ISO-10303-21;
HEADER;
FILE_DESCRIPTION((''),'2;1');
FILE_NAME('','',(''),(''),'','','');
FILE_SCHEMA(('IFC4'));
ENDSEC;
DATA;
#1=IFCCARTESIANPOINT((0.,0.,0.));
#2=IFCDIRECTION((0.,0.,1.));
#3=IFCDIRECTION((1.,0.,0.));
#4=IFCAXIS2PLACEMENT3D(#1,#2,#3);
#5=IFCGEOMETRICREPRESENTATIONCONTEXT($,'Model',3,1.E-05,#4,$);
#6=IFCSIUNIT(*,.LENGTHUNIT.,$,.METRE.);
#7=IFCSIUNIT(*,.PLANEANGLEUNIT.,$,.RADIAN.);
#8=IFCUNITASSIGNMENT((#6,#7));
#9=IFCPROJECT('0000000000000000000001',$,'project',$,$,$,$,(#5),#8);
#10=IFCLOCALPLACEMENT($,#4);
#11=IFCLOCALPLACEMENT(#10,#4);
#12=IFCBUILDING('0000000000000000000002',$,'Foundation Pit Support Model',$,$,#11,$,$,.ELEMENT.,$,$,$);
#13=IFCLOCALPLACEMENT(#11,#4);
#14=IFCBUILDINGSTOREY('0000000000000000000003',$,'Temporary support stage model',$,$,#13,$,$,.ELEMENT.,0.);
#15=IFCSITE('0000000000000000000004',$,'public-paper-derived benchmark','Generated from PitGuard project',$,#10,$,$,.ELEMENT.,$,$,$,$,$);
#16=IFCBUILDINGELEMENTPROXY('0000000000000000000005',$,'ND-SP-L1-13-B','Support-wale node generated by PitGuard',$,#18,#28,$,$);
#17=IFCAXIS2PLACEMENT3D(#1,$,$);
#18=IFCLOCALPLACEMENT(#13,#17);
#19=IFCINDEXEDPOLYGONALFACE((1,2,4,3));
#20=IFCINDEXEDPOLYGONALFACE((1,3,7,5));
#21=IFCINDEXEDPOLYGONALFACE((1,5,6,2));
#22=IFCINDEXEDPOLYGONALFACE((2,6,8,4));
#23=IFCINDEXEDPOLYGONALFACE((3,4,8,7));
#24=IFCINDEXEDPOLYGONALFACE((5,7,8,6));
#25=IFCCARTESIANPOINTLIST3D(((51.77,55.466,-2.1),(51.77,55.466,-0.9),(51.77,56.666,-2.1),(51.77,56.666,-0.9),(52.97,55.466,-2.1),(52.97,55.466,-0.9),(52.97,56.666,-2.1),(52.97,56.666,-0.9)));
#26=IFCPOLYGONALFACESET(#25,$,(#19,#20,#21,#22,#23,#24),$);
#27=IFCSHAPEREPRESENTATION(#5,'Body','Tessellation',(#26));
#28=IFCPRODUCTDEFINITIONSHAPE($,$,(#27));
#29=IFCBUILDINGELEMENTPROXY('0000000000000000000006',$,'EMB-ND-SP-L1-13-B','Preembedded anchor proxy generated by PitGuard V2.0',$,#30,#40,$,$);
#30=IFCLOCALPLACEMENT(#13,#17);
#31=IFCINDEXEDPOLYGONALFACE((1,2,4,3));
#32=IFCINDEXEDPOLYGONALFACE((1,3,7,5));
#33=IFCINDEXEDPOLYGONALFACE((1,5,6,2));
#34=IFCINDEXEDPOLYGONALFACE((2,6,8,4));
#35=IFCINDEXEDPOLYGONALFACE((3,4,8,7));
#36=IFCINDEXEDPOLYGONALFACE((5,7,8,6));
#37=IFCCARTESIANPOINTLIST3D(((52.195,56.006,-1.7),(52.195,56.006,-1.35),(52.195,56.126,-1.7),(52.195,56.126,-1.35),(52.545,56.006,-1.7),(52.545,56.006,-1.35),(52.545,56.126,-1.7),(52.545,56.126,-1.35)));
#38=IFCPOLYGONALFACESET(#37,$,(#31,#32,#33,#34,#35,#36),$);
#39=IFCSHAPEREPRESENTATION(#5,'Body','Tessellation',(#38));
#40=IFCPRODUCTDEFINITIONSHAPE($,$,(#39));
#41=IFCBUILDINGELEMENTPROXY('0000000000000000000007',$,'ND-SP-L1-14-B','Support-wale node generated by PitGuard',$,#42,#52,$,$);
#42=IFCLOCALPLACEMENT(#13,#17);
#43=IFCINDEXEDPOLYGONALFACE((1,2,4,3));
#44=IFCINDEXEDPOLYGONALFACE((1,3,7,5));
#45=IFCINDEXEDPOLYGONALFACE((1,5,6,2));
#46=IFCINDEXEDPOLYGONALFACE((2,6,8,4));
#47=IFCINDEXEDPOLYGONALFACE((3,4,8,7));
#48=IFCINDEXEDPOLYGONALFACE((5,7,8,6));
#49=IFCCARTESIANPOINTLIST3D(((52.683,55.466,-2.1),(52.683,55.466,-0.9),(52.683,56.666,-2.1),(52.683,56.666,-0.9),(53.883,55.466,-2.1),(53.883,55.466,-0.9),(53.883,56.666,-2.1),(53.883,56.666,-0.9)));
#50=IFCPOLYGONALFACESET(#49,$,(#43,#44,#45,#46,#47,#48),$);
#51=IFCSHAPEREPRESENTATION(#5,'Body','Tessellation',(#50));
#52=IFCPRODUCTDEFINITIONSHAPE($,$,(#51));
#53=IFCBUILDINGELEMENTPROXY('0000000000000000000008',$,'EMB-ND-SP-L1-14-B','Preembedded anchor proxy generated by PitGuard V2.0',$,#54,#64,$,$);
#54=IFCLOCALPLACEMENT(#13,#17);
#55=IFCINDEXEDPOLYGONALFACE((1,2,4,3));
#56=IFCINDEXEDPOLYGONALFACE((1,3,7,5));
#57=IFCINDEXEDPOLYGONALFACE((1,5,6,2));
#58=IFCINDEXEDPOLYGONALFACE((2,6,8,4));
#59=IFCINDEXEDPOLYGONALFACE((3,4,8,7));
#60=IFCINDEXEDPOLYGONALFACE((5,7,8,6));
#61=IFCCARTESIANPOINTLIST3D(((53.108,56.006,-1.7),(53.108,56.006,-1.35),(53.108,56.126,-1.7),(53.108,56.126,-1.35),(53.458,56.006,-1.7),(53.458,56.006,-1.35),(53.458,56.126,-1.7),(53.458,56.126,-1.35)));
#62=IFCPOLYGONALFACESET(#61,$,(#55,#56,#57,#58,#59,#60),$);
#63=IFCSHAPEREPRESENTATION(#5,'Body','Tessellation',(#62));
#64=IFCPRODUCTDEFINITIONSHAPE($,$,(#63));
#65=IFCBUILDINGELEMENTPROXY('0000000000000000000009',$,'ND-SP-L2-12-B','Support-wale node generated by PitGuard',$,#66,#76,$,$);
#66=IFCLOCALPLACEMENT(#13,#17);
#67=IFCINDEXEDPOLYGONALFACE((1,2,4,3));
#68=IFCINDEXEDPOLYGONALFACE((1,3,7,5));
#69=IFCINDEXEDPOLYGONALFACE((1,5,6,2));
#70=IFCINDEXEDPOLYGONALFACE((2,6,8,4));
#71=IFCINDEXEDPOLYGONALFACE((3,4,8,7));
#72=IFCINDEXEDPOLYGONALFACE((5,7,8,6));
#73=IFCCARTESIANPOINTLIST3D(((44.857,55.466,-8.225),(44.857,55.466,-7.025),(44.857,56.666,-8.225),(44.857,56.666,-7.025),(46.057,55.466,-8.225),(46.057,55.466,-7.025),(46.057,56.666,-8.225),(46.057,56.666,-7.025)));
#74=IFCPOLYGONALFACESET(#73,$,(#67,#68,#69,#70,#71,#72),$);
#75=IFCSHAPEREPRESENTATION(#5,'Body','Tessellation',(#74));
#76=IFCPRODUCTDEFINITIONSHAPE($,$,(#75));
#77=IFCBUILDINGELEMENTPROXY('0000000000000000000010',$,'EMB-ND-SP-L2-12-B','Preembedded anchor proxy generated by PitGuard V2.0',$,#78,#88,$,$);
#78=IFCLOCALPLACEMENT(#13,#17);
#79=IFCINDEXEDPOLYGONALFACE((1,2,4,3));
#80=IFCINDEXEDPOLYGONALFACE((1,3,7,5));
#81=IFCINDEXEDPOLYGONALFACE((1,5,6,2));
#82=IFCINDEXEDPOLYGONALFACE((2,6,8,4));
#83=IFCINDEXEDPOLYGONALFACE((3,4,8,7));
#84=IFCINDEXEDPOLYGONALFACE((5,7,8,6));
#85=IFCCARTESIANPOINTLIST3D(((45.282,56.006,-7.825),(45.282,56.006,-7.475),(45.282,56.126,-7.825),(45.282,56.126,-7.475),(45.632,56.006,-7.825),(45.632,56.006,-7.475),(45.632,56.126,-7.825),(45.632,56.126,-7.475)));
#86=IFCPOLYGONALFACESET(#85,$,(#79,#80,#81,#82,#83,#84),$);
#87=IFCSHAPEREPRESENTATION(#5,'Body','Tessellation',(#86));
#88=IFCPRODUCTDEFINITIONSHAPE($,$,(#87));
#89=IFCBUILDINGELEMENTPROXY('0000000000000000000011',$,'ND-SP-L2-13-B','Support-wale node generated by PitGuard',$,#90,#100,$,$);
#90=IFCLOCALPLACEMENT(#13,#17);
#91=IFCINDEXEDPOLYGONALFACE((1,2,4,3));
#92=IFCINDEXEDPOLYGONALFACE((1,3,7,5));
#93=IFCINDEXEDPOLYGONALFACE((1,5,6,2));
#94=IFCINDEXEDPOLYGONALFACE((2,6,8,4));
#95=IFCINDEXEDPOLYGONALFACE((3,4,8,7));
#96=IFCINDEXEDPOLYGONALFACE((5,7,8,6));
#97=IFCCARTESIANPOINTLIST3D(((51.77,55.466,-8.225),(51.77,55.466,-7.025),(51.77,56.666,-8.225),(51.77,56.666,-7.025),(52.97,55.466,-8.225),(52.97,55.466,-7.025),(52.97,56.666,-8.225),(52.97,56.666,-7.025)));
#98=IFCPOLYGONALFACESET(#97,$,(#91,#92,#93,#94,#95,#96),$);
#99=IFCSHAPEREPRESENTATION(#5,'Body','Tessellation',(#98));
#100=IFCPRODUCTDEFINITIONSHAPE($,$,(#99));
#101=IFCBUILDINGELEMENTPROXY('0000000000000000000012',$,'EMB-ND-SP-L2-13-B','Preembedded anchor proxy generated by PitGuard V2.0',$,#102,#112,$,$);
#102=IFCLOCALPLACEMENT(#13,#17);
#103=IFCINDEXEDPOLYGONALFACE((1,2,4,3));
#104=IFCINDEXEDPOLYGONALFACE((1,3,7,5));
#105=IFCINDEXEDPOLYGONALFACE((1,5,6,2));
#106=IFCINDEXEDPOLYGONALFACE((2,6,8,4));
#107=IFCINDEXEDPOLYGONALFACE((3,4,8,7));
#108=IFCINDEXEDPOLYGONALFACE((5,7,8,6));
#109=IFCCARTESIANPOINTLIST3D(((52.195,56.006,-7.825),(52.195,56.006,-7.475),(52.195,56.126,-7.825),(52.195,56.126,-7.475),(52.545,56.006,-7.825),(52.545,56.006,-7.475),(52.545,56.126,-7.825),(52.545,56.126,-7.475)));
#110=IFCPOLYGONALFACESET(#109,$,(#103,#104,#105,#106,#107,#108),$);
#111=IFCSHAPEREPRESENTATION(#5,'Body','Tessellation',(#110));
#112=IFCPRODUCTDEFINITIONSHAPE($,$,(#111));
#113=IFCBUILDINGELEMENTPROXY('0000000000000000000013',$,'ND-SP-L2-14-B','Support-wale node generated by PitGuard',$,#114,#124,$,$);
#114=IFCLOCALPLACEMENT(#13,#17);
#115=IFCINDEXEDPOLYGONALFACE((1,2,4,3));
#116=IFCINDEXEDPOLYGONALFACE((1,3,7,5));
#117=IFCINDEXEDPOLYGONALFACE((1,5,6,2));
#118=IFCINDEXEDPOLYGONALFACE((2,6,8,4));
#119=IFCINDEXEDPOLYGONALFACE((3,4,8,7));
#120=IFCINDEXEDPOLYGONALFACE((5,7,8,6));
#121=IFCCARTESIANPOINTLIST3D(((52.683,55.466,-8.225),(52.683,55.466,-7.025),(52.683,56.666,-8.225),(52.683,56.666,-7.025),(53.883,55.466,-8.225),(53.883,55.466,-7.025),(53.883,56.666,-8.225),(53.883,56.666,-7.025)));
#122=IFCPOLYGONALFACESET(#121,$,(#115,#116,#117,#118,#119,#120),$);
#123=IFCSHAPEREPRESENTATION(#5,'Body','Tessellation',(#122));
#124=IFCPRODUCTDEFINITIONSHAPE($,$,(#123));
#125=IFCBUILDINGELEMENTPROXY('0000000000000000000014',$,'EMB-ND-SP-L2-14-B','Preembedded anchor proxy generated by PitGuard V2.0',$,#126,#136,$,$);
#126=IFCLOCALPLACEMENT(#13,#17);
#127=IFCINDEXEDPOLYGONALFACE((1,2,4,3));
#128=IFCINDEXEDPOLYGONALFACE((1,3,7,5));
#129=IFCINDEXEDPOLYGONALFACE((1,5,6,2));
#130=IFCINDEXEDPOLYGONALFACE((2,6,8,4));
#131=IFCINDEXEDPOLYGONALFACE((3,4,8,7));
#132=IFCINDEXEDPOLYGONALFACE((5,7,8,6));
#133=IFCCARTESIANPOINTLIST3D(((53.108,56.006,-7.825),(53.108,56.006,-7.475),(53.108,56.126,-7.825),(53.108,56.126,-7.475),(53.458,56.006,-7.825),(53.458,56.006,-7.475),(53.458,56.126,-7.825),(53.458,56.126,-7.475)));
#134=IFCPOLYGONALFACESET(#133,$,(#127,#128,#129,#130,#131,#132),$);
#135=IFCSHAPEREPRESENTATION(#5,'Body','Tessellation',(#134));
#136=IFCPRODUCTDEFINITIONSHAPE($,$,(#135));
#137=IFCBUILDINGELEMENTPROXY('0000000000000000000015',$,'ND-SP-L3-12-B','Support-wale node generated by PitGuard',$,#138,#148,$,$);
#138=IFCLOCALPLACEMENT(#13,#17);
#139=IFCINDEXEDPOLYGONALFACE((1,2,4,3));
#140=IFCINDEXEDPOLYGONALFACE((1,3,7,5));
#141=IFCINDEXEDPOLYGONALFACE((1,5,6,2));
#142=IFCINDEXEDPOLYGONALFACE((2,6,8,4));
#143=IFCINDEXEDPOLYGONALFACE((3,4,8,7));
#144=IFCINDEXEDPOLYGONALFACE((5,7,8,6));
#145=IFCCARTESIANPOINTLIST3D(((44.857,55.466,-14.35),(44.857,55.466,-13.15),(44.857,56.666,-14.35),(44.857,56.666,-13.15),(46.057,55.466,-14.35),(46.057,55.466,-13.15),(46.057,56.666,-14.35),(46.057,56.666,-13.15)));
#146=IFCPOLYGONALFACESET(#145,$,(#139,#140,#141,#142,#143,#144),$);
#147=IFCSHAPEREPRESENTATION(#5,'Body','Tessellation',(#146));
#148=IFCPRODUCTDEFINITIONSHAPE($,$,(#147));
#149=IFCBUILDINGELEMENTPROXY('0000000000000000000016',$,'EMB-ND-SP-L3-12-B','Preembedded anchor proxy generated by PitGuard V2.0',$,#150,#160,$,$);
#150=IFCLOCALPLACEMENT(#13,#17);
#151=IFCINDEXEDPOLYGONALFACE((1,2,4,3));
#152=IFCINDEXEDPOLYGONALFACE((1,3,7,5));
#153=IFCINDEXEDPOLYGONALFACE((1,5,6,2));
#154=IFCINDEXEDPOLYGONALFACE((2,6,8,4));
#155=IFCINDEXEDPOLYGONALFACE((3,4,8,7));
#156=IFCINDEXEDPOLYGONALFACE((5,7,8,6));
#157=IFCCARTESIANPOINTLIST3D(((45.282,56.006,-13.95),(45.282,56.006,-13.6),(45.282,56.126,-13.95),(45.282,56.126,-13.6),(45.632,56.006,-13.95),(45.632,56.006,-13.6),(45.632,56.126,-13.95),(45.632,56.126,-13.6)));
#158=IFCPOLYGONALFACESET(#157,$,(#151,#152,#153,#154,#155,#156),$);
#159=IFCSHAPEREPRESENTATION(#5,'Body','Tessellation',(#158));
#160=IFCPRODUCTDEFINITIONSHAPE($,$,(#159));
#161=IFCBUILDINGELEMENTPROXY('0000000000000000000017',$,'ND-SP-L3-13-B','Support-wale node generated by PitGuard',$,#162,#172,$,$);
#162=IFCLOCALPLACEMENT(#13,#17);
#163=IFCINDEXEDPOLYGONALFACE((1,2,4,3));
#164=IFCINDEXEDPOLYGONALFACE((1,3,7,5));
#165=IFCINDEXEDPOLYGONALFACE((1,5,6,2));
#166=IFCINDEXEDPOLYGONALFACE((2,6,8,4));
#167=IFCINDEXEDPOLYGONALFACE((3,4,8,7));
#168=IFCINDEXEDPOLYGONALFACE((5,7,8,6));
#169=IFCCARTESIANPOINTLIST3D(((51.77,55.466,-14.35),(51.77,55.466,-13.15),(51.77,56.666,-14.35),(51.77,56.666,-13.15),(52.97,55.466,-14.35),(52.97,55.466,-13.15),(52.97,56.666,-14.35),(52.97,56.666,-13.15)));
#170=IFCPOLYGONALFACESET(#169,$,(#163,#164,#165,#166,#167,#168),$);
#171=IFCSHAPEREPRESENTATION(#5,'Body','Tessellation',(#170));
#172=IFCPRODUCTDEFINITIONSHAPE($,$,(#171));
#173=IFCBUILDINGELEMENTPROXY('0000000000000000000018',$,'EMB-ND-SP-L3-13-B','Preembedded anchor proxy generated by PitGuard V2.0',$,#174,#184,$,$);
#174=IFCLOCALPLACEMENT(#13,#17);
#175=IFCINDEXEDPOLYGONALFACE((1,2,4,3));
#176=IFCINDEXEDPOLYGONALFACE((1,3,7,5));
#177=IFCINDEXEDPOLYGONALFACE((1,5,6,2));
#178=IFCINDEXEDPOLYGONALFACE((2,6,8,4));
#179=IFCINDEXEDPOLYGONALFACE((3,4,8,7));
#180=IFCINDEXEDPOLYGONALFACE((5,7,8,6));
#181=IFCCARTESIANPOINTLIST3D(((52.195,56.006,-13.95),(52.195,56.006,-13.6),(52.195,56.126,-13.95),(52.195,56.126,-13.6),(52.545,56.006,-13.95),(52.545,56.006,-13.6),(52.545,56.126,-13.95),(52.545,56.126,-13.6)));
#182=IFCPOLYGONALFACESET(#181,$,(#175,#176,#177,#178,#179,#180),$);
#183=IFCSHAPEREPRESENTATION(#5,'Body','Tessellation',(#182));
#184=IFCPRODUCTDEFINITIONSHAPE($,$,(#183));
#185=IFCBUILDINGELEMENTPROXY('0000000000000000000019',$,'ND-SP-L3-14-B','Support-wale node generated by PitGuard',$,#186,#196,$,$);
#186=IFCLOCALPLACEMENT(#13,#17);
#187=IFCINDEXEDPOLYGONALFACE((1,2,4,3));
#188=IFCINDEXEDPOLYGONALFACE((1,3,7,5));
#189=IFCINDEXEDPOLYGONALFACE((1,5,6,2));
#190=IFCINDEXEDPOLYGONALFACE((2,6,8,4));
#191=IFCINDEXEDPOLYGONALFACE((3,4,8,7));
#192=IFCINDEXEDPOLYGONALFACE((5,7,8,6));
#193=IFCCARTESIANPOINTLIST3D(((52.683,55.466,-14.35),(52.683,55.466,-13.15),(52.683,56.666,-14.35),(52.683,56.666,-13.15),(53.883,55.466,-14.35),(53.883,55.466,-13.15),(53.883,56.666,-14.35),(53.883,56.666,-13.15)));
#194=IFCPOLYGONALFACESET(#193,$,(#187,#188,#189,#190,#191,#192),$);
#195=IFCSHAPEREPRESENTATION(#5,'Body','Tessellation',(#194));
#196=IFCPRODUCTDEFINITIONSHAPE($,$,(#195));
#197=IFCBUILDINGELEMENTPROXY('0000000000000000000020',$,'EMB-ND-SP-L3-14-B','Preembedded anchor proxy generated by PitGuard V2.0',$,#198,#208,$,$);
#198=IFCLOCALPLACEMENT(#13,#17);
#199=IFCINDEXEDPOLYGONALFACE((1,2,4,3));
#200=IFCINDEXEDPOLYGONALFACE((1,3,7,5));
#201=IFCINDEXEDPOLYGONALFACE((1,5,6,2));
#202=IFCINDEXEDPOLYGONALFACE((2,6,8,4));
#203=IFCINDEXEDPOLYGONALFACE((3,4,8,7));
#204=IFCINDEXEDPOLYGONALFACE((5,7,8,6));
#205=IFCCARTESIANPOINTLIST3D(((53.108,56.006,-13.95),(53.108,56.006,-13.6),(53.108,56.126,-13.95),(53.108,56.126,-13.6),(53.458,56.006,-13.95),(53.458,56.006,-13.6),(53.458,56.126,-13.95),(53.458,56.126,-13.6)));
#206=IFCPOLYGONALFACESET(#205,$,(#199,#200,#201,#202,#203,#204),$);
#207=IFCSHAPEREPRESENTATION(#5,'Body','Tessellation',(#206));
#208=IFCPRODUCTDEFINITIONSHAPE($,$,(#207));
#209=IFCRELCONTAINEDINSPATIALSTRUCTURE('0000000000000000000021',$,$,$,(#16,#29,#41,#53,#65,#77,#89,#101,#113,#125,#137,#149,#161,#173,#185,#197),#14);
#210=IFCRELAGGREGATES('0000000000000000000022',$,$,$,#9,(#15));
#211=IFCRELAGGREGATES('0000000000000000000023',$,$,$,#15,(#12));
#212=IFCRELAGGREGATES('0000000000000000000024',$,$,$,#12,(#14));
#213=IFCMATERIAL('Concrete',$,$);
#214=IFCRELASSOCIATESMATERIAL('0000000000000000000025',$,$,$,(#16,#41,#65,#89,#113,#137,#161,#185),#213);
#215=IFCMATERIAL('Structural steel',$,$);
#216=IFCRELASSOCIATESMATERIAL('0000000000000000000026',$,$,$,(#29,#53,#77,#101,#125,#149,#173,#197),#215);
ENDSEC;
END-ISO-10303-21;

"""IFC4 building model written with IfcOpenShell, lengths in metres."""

from ifc_helpers import new_model, si_unit, frame, origin_with_axes, origin_2d, place, context, project, spatial, rectangle, extrude, material, element, save


model = new_model("IFC4")

# Units and contexts
model_context = context("Model", 3, precision=1e-05, world=origin_with_axes())
ifc_project = project(units=[si_unit("LENGTHUNIT", "METRE"), si_unit("PLANEANGLEUNIT", "RADIAN")], contexts=[model_context])

# Site, building, storey
site_placement = place(None, origin_with_axes())
site = spatial("IfcSite", under=ifc_project, at=site_placement, Name="public-paper-derived benchmark", Description="Generated from PitGuard project", CompositionType="ELEMENT")
building_placement = place(site_placement, origin_with_axes())
building = spatial("IfcBuilding", under=site, at=building_placement, Name="Foundation Pit Support Model", CompositionType="ELEMENT")
storey_placement = place(building_placement, origin_with_axes())
storey = spatial("IfcBuildingStorey", under=building, at=storey_placement, Name="Temporary support stage model", CompositionType="ELEMENT", Elevation=0.0)

# Shared definitions
ifc_material_1 = material(Name="Concrete")

# Shared definitions
ifc_material_2 = material(Name="Structural steel")

# Building element proxies
proxy_1_placement = place(storey_placement, frame((52.37, 56.066, -2.1), z_axis=(0.0, 0.0, 1.0), x_axis=(1.0, 0.0, 0.0)))
element("IfcBuildingElementProxy", 1, at=proxy_1_placement, inside=storey, material=ifc_material_1, Name="ND-SP-L1-13-B", Description="Support-wale node generated by PitGuard", context=model_context, shape_type="SweptSolid", body=[
    extrude(rectangle(XDim=1.2, YDim=1.2, at=origin_2d()), origin_with_axes(), (0.0, 0.0, 1.0), 1.2),
])
proxy_2_placement = place(storey_placement, frame((52.37, 56.066, -1.7), z_axis=(0.0, 0.0, 1.0), x_axis=(1.0, 0.0, 0.0)))
element("IfcBuildingElementProxy", 2, at=proxy_2_placement, inside=storey, material=ifc_material_2, Name="EMB-ND-SP-L1-13-B", Description="Preembedded anchor proxy generated by PitGuard V2.0", context=model_context, shape_type="SweptSolid", body=[
    extrude(rectangle(XDim=0.35, YDim=0.12, at=origin_2d()), origin_with_axes(), (0.0, 0.0, 1.0), 0.35),
])
proxy_3_placement = place(storey_placement, frame((53.283, 56.066, -2.1), z_axis=(0.0, 0.0, 1.0), x_axis=(1.0, 0.0, 0.0)))
element("IfcBuildingElementProxy", 3, at=proxy_3_placement, inside=storey, material=ifc_material_1, Name="ND-SP-L1-14-B", Description="Support-wale node generated by PitGuard", context=model_context, shape_type="SweptSolid", body=[
    extrude(rectangle(XDim=1.2, YDim=1.2, at=origin_2d()), origin_with_axes(), (0.0, 0.0, 1.0), 1.2),
])
proxy_4_placement = place(storey_placement, frame((53.283, 56.066, -1.7), z_axis=(0.0, 0.0, 1.0), x_axis=(1.0, 0.0, 0.0)))
element("IfcBuildingElementProxy", 4, at=proxy_4_placement, inside=storey, material=ifc_material_2, Name="EMB-ND-SP-L1-14-B", Description="Preembedded anchor proxy generated by PitGuard V2.0", context=model_context, shape_type="SweptSolid", body=[
    extrude(rectangle(XDim=0.35, YDim=0.12, at=origin_2d()), origin_with_axes(), (0.0, 0.0, 1.0), 0.35),
])
proxy_5_placement = place(storey_placement, frame((45.457, 56.066, -8.225), z_axis=(0.0, 0.0, 1.0), x_axis=(1.0, 0.0, 0.0)))
element("IfcBuildingElementProxy", 5, at=proxy_5_placement, inside=storey, material=ifc_material_1, Name="ND-SP-L2-12-B", Description="Support-wale node generated by PitGuard", context=model_context, shape_type="SweptSolid", body=[
    extrude(rectangle(XDim=1.2, YDim=1.2, at=origin_2d()), origin_with_axes(), (0.0, 0.0, 1.0), 1.2),
])
proxy_6_placement = place(storey_placement, frame((45.457, 56.066, -7.825), z_axis=(0.0, 0.0, 1.0), x_axis=(1.0, 0.0, 0.0)))
element("IfcBuildingElementProxy", 6, at=proxy_6_placement, inside=storey, material=ifc_material_2, Name="EMB-ND-SP-L2-12-B", Description="Preembedded anchor proxy generated by PitGuard V2.0", context=model_context, shape_type="SweptSolid", body=[
    extrude(rectangle(XDim=0.35, YDim=0.12, at=origin_2d()), origin_with_axes(), (0.0, 0.0, 1.0), 0.35),
])
proxy_7_placement = place(storey_placement, frame((52.37, 56.066, -8.225), z_axis=(0.0, 0.0, 1.0), x_axis=(1.0, 0.0, 0.0)))
element("IfcBuildingElementProxy", 7, at=proxy_7_placement, inside=storey, material=ifc_material_1, Name="ND-SP-L2-13-B", Description="Support-wale node generated by PitGuard", context=model_context, shape_type="SweptSolid", body=[
    extrude(rectangle(XDim=1.2, YDim=1.2, at=origin_2d()), origin_with_axes(), (0.0, 0.0, 1.0), 1.2),
])
proxy_8_placement = place(storey_placement, frame((52.37, 56.066, -7.825), z_axis=(0.0, 0.0, 1.0), x_axis=(1.0, 0.0, 0.0)))
element("IfcBuildingElementProxy", 8, at=proxy_8_placement, inside=storey, material=ifc_material_2, Name="EMB-ND-SP-L2-13-B", Description="Preembedded anchor proxy generated by PitGuard V2.0", context=model_context, shape_type="SweptSolid", body=[
    extrude(rectangle(XDim=0.35, YDim=0.12, at=origin_2d()), origin_with_axes(), (0.0, 0.0, 1.0), 0.35),
])
proxy_9_placement = place(storey_placement, frame((53.283, 56.066, -8.225), z_axis=(0.0, 0.0, 1.0), x_axis=(1.0, 0.0, 0.0)))
element("IfcBuildingElementProxy", 9, at=proxy_9_placement, inside=storey, material=ifc_material_1, Name="ND-SP-L2-14-B", Description="Support-wale node generated by PitGuard", context=model_context, shape_type="SweptSolid", body=[
    extrude(rectangle(XDim=1.2, YDim=1.2, at=origin_2d()), origin_with_axes(), (0.0, 0.0, 1.0), 1.2),
])
proxy_10_placement = place(storey_placement, frame((53.283, 56.066, -7.825), z_axis=(0.0, 0.0, 1.0), x_axis=(1.0, 0.0, 0.0)))
element("IfcBuildingElementProxy", 10, at=proxy_10_placement, inside=storey, material=ifc_material_2, Name="EMB-ND-SP-L2-14-B", Description="Preembedded anchor proxy generated by PitGuard V2.0", context=model_context, shape_type="SweptSolid", body=[
    extrude(rectangle(XDim=0.35, YDim=0.12, at=origin_2d()), origin_with_axes(), (0.0, 0.0, 1.0), 0.35),
])
proxy_11_placement = place(storey_placement, frame((45.457, 56.066, -14.35), z_axis=(0.0, 0.0, 1.0), x_axis=(1.0, 0.0, 0.0)))
element("IfcBuildingElementProxy", 11, at=proxy_11_placement, inside=storey, material=ifc_material_1, Name="ND-SP-L3-12-B", Description="Support-wale node generated by PitGuard", context=model_context, shape_type="SweptSolid", body=[
    extrude(rectangle(XDim=1.2, YDim=1.2, at=origin_2d()), origin_with_axes(), (0.0, 0.0, 1.0), 1.2),
])
proxy_12_placement = place(storey_placement, frame((45.457, 56.066, -13.95), z_axis=(0.0, 0.0, 1.0), x_axis=(1.0, 0.0, 0.0)))
element("IfcBuildingElementProxy", 12, at=proxy_12_placement, inside=storey, material=ifc_material_2, Name="EMB-ND-SP-L3-12-B", Description="Preembedded anchor proxy generated by PitGuard V2.0", context=model_context, shape_type="SweptSolid", body=[
    extrude(rectangle(XDim=0.35, YDim=0.12, at=origin_2d()), origin_with_axes(), (0.0, 0.0, 1.0), 0.35),
])
proxy_13_placement = place(storey_placement, frame((52.37, 56.066, -14.35), z_axis=(0.0, 0.0, 1.0), x_axis=(1.0, 0.0, 0.0)))
element("IfcBuildingElementProxy", 13, at=proxy_13_placement, inside=storey, material=ifc_material_1, Name="ND-SP-L3-13-B", Description="Support-wale node generated by PitGuard", context=model_context, shape_type="SweptSolid", body=[
    extrude(rectangle(XDim=1.2, YDim=1.2, at=origin_2d()), origin_with_axes(), (0.0, 0.0, 1.0), 1.2),
])
proxy_14_placement = place(storey_placement, frame((52.37, 56.066, -13.95), z_axis=(0.0, 0.0, 1.0), x_axis=(1.0, 0.0, 0.0)))
element("IfcBuildingElementProxy", 14, at=proxy_14_placement, inside=storey, material=ifc_material_2, Name="EMB-ND-SP-L3-13-B", Description="Preembedded anchor proxy generated by PitGuard V2.0", context=model_context, shape_type="SweptSolid", body=[
    extrude(rectangle(XDim=0.35, YDim=0.12, at=origin_2d()), origin_with_axes(), (0.0, 0.0, 1.0), 0.35),
])
proxy_15_placement = place(storey_placement, frame((53.283, 56.066, -14.35), z_axis=(0.0, 0.0, 1.0), x_axis=(1.0, 0.0, 0.0)))
element("IfcBuildingElementProxy", 15, at=proxy_15_placement, inside=storey, material=ifc_material_1, Name="ND-SP-L3-14-B", Description="Support-wale node generated by PitGuard", context=model_context, shape_type="SweptSolid", body=[
    extrude(rectangle(XDim=1.2, YDim=1.2, at=origin_2d()), origin_with_axes(), (0.0, 0.0, 1.0), 1.2),
])
proxy_16_placement = place(storey_placement, frame((53.283, 56.066, -13.95), z_axis=(0.0, 0.0, 1.0), x_axis=(1.0, 0.0, 0.0)))
element("IfcBuildingElementProxy", 16, at=proxy_16_placement, inside=storey, material=ifc_material_2, Name="EMB-ND-SP-L3-14-B", Description="Preembedded anchor proxy generated by PitGuard V2.0", context=model_context, shape_type="SweptSolid", body=[
    extrude(rectangle(XDim=0.35, YDim=0.12, at=origin_2d()), origin_with_axes(), (0.0, 0.0, 1.0), 0.35),
])

save(model, "model.ifc")
